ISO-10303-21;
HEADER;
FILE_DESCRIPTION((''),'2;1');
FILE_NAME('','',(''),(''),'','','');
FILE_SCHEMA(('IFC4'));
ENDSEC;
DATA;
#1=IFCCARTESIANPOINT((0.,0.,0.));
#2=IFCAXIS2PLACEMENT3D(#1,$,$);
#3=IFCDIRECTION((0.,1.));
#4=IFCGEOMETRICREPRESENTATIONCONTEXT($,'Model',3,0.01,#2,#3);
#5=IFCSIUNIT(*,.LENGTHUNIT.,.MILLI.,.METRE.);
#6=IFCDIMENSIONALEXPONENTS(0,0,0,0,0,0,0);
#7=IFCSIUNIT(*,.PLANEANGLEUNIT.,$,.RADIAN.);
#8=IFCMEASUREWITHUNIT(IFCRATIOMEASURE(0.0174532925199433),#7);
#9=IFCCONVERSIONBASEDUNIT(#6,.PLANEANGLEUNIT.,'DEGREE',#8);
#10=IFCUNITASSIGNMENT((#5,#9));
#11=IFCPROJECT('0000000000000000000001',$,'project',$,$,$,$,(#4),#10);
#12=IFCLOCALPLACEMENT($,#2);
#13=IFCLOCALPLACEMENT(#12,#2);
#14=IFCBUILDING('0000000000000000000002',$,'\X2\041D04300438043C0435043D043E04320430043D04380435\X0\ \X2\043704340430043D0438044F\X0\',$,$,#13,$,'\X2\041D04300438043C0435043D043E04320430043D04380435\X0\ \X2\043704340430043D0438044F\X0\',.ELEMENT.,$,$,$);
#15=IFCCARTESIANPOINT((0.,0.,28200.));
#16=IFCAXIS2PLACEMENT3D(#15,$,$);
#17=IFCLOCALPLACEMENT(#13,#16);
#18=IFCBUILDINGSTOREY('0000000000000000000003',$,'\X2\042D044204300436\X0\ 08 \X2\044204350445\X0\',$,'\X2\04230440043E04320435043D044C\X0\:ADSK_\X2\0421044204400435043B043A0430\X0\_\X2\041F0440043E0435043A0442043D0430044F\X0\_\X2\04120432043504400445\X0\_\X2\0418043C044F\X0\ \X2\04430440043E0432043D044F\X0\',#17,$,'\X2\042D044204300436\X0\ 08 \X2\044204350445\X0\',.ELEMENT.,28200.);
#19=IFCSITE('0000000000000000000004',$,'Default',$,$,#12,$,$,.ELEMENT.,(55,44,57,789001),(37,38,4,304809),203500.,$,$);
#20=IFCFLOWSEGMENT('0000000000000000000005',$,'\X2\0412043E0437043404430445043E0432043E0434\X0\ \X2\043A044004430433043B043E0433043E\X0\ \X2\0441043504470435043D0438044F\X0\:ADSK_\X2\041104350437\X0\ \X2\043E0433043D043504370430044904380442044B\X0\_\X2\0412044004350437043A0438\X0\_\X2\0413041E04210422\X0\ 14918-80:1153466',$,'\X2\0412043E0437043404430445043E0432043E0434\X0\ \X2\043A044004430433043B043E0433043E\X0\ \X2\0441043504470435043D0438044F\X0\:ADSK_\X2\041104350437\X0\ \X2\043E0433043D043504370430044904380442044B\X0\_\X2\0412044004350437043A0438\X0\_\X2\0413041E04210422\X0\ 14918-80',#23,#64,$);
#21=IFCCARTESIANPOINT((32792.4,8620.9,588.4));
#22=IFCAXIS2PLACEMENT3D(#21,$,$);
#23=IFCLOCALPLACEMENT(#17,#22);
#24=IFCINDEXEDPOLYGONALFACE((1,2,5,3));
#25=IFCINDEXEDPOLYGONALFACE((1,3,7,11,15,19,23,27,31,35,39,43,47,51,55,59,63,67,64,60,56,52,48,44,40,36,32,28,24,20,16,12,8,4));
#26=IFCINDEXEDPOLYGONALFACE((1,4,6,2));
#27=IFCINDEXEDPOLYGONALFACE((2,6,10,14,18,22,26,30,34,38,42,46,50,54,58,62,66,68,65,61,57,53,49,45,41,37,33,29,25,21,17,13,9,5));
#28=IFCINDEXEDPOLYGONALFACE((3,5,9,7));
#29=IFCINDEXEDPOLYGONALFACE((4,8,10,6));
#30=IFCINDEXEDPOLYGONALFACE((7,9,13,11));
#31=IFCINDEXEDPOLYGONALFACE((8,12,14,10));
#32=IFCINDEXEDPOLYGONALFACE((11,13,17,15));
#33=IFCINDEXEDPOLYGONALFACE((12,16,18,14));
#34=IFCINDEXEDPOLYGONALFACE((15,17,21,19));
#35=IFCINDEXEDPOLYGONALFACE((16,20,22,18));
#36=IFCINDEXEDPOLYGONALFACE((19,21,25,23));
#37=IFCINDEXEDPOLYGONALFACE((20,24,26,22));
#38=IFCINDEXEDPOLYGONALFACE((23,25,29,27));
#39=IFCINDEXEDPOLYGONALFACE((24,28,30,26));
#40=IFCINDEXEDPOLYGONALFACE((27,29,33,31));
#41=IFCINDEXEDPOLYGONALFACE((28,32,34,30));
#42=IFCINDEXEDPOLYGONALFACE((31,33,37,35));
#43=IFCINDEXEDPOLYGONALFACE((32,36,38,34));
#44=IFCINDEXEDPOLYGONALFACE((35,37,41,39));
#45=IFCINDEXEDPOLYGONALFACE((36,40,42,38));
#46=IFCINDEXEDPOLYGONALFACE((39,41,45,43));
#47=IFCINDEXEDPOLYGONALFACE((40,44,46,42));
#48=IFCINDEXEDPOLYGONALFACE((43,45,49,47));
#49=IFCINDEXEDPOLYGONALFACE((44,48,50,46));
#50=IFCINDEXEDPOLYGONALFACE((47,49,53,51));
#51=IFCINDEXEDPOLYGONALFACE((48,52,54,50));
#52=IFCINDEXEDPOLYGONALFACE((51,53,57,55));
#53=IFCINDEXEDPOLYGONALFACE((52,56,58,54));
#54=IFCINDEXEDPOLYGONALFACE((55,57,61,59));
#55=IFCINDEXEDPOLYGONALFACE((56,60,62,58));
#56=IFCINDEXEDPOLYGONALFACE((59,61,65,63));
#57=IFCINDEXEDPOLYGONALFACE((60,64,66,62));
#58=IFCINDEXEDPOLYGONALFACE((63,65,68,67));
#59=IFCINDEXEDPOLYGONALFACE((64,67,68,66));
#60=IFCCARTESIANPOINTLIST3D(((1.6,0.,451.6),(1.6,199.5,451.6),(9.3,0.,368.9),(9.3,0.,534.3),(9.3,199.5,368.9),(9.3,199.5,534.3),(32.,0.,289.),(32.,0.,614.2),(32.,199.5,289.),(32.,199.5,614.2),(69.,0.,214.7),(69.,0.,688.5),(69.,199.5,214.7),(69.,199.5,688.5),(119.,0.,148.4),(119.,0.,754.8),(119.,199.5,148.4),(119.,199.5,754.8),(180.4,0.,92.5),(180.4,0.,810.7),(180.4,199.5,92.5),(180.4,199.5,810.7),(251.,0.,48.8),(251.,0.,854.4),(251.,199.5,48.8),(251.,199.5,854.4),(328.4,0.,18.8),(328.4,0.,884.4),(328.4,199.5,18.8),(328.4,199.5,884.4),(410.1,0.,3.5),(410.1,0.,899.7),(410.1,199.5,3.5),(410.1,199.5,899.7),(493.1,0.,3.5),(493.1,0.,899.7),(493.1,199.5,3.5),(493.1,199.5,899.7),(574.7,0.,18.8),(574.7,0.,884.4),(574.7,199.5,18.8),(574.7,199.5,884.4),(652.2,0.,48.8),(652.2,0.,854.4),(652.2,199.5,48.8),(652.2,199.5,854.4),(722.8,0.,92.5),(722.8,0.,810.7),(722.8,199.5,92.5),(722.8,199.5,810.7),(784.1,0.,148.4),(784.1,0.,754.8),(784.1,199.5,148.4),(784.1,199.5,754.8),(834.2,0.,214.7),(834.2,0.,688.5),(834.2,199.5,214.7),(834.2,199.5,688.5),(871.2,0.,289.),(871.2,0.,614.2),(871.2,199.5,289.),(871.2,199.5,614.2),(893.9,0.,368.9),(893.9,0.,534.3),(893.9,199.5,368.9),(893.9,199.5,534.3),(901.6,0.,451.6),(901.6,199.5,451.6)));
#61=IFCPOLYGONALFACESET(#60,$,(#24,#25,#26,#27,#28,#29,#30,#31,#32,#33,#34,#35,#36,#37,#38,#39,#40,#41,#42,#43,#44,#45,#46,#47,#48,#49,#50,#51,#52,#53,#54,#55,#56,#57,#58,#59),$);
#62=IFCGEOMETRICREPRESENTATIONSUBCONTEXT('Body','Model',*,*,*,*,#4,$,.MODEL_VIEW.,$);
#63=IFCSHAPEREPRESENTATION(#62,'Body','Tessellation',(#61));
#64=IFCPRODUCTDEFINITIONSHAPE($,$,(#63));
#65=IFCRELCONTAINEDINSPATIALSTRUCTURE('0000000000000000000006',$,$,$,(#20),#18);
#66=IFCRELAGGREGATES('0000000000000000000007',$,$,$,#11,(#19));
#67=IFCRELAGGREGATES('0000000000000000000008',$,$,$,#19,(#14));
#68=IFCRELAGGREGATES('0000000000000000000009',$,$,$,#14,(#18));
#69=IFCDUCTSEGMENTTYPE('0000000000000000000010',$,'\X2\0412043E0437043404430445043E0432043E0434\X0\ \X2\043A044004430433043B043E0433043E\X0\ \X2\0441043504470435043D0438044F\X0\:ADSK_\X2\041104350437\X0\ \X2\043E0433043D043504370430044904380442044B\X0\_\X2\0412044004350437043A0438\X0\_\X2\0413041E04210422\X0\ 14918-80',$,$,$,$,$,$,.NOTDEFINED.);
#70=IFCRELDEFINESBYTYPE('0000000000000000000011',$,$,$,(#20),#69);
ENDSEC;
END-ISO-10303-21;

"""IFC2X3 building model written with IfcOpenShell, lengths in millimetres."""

from ifc_helpers import new_model, entity, si_unit, converted_unit, direction, frame, frame_2d, origin, place, context, subcontext, project, spatial, circle, extrude, type_object, element, save


model = new_model("IFC2X3")

# Units and contexts
model_context = context("Model", 3, precision=0.01, world=origin(), true_north=direction((0.0, 1.0)))
body_context = subcontext(model_context, "Body", "Model", "MODEL_VIEW")
ifc_project = project(units=[si_unit("LENGTHUNIT", "METRE", prefix="MILLI"), converted_unit("PLANEANGLEUNIT", "DEGREE", entity("IfcRatioMeasure", 0.0174532925199433), si_unit("PLANEANGLEUNIT", "RADIAN"), dimensions=[0, 0, 0, 0, 0, 0, 0])], contexts=[model_context])

# Site, building, storey
site_placement = place(None, frame((0.0, 0.0, 0.0)))
site = spatial("IfcSite", under=ifc_project, at=site_placement, Name="Default", CompositionType="ELEMENT", RefLatitude=(55, 44, 57, 789001), RefLongitude=(37, 38, 4, 304809), RefElevation=203500.0)
building_placement = place(site_placement, origin())
building = spatial("IfcBuilding", under=site, at=building_placement, Name="Наименование здания", LongName="Наименование здания", CompositionType="ELEMENT")
storey_placement = place(building_placement, frame((0.0, 0.0, 28200.0)))
storey = spatial("IfcBuildingStorey", under=building, at=storey_placement, Name="Этаж 08 тех", ObjectType="Уровень:ADSK_Стрелка_Проектная_Вверх_Имя уровня", LongName="Этаж 08 тех", CompositionType="ELEMENT", Elevation=28200.0)

# Flow segment
duct_segment_type_1 = type_object("IfcDuctSegmentType", Name="Воздуховод круглого сечения:ADSK_Без огнезащиты_Врезки_ГОСТ 14918-80", PredefinedType="NOTDEFINED")
flow_segment_1_placement = place(storey_placement, frame((32792.4, 8620.9, 588.4)))
element("IfcFlowSegment", 1, at=flow_segment_1_placement, inside=storey, type_object=duct_segment_type_1, Name="Воздуховод круглого сечения:ADSK_Без огнезащиты_Врезки_ГОСТ 14918-80:1153466", ObjectType="Воздуховод круглого сечения:ADSK_Без огнезащиты_Врезки_ГОСТ 14918-80", context=body_context, shape_type="SweptSolid", body=[
    extrude(circle(Radius=450.0, at=frame_2d((0.0, 0.0), x_axis=(1.0, 0.0))), frame((451.6, 0.0, 451.6), z_axis=(0.0, 1.0, 0.0), x_axis=(-1.0, 0.0, 0.0)), (0.0, 0.0, 1.0), 199.5),
])

save(model, "model.ifc")
